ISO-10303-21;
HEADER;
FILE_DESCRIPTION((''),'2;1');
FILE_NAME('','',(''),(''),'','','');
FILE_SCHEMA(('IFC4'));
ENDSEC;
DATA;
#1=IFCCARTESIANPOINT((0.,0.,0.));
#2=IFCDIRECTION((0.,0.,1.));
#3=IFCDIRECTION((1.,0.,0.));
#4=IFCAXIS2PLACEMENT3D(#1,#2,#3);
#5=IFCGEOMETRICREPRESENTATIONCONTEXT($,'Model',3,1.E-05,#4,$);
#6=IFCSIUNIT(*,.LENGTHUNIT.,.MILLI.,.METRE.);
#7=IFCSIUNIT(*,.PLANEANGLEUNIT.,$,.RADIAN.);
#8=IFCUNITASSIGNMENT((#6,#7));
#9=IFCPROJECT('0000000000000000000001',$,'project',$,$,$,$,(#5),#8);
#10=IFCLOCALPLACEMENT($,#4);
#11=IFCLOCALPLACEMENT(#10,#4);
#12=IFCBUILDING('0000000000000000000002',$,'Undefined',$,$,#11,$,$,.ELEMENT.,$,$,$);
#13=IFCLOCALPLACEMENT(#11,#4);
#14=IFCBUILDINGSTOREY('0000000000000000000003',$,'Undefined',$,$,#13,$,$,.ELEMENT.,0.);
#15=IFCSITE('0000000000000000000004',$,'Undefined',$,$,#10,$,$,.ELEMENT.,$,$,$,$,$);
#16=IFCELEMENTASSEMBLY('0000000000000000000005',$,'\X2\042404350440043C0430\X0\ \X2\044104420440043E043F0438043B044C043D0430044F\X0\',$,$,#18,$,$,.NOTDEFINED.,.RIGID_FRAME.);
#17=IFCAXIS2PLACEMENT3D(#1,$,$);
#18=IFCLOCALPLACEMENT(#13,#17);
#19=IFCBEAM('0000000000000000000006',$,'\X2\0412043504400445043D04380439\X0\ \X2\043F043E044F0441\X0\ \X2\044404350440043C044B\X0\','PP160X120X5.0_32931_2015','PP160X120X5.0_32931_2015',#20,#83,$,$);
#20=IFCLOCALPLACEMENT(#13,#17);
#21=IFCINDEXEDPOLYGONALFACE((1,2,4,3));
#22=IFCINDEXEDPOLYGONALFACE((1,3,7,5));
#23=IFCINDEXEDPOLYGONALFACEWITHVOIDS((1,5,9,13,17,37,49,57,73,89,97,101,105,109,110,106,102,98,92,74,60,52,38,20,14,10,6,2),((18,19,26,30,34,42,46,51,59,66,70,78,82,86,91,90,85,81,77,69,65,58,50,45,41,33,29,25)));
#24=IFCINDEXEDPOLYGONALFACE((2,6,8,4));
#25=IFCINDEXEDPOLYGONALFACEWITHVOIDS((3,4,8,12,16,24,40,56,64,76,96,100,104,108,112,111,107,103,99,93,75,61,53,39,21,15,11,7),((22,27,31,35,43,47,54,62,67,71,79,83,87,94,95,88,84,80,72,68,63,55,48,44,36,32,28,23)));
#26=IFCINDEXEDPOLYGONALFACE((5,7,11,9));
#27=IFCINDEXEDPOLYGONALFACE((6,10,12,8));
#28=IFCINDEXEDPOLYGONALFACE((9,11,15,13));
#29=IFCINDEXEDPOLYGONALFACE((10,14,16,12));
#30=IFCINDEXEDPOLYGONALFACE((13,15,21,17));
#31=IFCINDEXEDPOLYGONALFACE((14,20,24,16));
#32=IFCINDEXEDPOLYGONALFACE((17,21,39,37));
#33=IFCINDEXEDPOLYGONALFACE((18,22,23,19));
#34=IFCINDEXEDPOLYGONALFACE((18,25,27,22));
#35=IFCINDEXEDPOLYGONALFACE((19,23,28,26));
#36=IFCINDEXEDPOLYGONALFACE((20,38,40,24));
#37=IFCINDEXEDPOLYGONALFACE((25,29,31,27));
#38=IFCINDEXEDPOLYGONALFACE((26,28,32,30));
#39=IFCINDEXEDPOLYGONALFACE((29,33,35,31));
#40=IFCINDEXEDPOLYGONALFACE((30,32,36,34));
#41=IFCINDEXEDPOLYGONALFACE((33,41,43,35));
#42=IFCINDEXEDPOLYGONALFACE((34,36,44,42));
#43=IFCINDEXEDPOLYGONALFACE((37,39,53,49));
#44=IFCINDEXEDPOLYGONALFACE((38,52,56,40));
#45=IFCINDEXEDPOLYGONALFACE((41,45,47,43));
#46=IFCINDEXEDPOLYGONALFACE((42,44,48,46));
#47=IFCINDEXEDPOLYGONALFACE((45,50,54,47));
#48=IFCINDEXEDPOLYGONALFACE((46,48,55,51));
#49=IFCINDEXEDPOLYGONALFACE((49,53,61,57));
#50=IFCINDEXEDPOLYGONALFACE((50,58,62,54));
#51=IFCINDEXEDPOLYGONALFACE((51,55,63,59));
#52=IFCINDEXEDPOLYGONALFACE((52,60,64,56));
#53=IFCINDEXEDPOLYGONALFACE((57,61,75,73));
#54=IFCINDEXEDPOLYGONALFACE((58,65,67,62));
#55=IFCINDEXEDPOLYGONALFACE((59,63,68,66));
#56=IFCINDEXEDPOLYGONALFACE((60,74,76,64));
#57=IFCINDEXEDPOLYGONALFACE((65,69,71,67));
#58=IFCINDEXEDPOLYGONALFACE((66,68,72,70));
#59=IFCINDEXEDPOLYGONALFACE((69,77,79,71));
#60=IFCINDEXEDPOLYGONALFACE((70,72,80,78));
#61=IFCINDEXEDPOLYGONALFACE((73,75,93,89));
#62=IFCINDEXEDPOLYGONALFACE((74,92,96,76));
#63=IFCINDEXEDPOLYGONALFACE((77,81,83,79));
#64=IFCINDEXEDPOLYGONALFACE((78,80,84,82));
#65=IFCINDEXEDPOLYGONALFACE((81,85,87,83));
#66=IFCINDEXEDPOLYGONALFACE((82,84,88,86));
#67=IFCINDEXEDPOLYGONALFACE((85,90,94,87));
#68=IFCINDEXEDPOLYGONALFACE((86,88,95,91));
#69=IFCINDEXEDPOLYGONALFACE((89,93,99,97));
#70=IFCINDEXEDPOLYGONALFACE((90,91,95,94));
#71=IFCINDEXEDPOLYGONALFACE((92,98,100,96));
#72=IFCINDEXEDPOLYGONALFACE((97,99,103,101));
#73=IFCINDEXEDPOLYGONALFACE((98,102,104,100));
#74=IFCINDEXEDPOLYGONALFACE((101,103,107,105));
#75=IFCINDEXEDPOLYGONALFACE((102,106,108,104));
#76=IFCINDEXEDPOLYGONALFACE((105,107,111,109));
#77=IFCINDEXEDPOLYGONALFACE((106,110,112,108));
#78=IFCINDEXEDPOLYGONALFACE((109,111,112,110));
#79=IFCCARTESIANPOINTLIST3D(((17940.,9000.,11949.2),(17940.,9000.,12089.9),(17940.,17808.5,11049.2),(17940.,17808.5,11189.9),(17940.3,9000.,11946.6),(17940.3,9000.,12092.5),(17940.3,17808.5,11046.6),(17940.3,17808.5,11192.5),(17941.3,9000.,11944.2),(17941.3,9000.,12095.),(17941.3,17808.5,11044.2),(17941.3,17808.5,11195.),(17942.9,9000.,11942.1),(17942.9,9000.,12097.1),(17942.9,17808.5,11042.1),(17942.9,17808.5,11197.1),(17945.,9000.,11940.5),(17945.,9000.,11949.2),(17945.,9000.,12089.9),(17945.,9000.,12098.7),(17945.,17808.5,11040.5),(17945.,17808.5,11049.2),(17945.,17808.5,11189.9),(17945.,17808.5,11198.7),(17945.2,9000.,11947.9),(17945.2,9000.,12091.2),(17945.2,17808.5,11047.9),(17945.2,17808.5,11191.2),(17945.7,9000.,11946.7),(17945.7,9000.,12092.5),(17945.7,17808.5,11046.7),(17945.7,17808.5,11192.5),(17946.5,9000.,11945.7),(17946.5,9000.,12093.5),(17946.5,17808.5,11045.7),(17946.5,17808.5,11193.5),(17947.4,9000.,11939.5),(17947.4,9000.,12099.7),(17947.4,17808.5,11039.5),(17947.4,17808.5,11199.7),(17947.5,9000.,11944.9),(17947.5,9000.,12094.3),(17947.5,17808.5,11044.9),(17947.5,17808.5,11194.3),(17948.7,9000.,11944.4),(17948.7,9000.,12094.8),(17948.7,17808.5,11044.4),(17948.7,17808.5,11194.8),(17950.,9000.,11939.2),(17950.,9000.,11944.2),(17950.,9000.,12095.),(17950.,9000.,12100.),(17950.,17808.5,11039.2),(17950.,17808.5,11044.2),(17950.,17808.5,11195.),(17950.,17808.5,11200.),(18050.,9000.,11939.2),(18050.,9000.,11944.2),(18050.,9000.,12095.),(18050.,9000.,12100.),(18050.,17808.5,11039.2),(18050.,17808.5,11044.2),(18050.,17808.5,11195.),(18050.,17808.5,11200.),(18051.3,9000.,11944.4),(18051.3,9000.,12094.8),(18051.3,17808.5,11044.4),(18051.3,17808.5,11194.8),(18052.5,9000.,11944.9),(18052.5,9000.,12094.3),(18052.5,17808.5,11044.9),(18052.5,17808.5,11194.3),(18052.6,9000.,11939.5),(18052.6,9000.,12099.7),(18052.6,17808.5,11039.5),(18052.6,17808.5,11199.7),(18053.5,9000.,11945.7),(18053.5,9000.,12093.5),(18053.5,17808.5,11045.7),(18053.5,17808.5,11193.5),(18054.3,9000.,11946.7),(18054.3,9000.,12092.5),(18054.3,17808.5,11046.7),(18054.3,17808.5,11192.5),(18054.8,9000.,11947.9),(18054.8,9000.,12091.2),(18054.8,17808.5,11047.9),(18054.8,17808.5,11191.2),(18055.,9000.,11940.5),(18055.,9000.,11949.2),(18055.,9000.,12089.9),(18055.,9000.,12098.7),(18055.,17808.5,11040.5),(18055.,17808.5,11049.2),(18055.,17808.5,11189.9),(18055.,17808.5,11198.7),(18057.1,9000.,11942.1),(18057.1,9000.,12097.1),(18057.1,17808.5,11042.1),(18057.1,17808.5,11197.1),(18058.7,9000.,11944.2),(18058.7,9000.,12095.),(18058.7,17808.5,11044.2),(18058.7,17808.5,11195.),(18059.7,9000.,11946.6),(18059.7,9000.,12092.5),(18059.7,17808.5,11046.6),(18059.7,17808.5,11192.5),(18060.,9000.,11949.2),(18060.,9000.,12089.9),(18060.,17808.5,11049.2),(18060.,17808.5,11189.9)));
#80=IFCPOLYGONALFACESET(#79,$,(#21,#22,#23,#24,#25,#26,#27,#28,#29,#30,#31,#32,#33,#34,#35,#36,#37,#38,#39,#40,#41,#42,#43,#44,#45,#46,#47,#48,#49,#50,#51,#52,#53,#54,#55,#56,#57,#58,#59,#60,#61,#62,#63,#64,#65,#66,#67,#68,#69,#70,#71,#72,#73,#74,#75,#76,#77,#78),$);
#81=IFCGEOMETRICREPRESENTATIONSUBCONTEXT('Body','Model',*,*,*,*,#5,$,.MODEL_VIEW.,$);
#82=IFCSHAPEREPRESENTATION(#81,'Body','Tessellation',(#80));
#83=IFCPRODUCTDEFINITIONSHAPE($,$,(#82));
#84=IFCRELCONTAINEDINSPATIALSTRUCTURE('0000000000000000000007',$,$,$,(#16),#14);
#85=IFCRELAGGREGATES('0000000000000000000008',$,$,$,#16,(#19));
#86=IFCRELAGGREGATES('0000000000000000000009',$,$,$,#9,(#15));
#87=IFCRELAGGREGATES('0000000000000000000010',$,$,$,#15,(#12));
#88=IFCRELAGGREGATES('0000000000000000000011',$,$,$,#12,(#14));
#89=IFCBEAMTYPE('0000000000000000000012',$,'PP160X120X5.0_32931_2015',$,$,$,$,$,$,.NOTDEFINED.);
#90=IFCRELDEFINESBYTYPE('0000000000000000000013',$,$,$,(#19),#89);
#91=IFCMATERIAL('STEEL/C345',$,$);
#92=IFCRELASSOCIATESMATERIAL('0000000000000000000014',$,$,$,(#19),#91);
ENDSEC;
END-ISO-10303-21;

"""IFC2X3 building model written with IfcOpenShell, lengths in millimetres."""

from ifc_helpers import new_model, si_unit, frame, origin_with_axes, origin_2d_with_axis, place, context, subcontext, project, spatial, hollow_rectangle, extrude, clip, halfspace, material, type_object, element, aggregate, save


model = new_model("IFC2X3")

# Units and contexts
model_context = context("Model", 3, precision=1e-05, world=origin_with_axes())
body_context = subcontext(model_context, "Body", "Model", "MODEL_VIEW")
ifc_project = project(units=[si_unit("LENGTHUNIT", "METRE", prefix="MILLI"), si_unit("PLANEANGLEUNIT", "RADIAN")], contexts=[model_context])

# Site, building, storey
site_placement = place(None, origin_with_axes())
site = spatial("IfcSite", under=ifc_project, at=site_placement, Name="Undefined", CompositionType="ELEMENT")
building_placement = place(site_placement, origin_with_axes())
building = spatial("IfcBuilding", under=site, at=building_placement, Name="Undefined", CompositionType="ELEMENT")
storey_placement = place(building_placement, origin_with_axes())
storey = spatial("IfcBuildingStorey", under=building, at=storey_placement, Name="Undefined", CompositionType="ELEMENT", Elevation=0.0)

# Element assembly
assembly_1_placement = place(storey_placement, origin_with_axes())
assembly_1 = element("IfcElementAssembly", 1, at=assembly_1_placement, inside=storey, Name="Ферма стропильная", AssemblyPlace="NOTDEFINED", PredefinedType="RIGID_FRAME")

# Beam
ifc_material_1 = material(Name="STEEL/C345")
beam_type_1 = type_object("IfcBeamType", Name="PP160X120X5.0_32931_2015", PredefinedType="NOTDEFINED")
beam_1_placement = place(assembly_1_placement, frame((18000.0, 17800.4, 11120.4), z_axis=(0.0, 0.101645, 0.994821), x_axis=(0.0, -0.994821, 0.101645)))
beam_1 = element("IfcBeam", 2, at=beam_1_placement, type_object=beam_type_1, material=ifc_material_1, Name="Верхний пояс фермы", Description="PP160X120X5.0_32931_2015", ObjectType="PP160X120X5.0_32931_2015", context=body_context, shape_type="Clipping", body=[
    clip(clip(extrude(hollow_rectangle(XDim=120.0, YDim=160.0, WallThickness=5.0, InnerFilletRadius=5.0, OuterFilletRadius=10.0, at=origin_2d_with_axis()), frame((8862.7, 0.0, 0.0), z_axis=(-1.0, 0.0, 0.0), x_axis=(0.0, -1.0, 0.0)), (0.0, 0.0, 1.0), 8887.4), halfspace(frame((8854.4, 0.0, 80.0), z_axis=(0.994821, 0.0, -0.101645), x_axis=(0.101645, 0.0, 0.994821)), False)), halfspace(frame((0.0, 0.0, 80.0), z_axis=(0.994821, 0.0, -0.101645), x_axis=(0.101645, 0.0, 0.994821)), True)),
])
aggregate(assembly_1, [beam_1])

save(model, "model.ifc")
